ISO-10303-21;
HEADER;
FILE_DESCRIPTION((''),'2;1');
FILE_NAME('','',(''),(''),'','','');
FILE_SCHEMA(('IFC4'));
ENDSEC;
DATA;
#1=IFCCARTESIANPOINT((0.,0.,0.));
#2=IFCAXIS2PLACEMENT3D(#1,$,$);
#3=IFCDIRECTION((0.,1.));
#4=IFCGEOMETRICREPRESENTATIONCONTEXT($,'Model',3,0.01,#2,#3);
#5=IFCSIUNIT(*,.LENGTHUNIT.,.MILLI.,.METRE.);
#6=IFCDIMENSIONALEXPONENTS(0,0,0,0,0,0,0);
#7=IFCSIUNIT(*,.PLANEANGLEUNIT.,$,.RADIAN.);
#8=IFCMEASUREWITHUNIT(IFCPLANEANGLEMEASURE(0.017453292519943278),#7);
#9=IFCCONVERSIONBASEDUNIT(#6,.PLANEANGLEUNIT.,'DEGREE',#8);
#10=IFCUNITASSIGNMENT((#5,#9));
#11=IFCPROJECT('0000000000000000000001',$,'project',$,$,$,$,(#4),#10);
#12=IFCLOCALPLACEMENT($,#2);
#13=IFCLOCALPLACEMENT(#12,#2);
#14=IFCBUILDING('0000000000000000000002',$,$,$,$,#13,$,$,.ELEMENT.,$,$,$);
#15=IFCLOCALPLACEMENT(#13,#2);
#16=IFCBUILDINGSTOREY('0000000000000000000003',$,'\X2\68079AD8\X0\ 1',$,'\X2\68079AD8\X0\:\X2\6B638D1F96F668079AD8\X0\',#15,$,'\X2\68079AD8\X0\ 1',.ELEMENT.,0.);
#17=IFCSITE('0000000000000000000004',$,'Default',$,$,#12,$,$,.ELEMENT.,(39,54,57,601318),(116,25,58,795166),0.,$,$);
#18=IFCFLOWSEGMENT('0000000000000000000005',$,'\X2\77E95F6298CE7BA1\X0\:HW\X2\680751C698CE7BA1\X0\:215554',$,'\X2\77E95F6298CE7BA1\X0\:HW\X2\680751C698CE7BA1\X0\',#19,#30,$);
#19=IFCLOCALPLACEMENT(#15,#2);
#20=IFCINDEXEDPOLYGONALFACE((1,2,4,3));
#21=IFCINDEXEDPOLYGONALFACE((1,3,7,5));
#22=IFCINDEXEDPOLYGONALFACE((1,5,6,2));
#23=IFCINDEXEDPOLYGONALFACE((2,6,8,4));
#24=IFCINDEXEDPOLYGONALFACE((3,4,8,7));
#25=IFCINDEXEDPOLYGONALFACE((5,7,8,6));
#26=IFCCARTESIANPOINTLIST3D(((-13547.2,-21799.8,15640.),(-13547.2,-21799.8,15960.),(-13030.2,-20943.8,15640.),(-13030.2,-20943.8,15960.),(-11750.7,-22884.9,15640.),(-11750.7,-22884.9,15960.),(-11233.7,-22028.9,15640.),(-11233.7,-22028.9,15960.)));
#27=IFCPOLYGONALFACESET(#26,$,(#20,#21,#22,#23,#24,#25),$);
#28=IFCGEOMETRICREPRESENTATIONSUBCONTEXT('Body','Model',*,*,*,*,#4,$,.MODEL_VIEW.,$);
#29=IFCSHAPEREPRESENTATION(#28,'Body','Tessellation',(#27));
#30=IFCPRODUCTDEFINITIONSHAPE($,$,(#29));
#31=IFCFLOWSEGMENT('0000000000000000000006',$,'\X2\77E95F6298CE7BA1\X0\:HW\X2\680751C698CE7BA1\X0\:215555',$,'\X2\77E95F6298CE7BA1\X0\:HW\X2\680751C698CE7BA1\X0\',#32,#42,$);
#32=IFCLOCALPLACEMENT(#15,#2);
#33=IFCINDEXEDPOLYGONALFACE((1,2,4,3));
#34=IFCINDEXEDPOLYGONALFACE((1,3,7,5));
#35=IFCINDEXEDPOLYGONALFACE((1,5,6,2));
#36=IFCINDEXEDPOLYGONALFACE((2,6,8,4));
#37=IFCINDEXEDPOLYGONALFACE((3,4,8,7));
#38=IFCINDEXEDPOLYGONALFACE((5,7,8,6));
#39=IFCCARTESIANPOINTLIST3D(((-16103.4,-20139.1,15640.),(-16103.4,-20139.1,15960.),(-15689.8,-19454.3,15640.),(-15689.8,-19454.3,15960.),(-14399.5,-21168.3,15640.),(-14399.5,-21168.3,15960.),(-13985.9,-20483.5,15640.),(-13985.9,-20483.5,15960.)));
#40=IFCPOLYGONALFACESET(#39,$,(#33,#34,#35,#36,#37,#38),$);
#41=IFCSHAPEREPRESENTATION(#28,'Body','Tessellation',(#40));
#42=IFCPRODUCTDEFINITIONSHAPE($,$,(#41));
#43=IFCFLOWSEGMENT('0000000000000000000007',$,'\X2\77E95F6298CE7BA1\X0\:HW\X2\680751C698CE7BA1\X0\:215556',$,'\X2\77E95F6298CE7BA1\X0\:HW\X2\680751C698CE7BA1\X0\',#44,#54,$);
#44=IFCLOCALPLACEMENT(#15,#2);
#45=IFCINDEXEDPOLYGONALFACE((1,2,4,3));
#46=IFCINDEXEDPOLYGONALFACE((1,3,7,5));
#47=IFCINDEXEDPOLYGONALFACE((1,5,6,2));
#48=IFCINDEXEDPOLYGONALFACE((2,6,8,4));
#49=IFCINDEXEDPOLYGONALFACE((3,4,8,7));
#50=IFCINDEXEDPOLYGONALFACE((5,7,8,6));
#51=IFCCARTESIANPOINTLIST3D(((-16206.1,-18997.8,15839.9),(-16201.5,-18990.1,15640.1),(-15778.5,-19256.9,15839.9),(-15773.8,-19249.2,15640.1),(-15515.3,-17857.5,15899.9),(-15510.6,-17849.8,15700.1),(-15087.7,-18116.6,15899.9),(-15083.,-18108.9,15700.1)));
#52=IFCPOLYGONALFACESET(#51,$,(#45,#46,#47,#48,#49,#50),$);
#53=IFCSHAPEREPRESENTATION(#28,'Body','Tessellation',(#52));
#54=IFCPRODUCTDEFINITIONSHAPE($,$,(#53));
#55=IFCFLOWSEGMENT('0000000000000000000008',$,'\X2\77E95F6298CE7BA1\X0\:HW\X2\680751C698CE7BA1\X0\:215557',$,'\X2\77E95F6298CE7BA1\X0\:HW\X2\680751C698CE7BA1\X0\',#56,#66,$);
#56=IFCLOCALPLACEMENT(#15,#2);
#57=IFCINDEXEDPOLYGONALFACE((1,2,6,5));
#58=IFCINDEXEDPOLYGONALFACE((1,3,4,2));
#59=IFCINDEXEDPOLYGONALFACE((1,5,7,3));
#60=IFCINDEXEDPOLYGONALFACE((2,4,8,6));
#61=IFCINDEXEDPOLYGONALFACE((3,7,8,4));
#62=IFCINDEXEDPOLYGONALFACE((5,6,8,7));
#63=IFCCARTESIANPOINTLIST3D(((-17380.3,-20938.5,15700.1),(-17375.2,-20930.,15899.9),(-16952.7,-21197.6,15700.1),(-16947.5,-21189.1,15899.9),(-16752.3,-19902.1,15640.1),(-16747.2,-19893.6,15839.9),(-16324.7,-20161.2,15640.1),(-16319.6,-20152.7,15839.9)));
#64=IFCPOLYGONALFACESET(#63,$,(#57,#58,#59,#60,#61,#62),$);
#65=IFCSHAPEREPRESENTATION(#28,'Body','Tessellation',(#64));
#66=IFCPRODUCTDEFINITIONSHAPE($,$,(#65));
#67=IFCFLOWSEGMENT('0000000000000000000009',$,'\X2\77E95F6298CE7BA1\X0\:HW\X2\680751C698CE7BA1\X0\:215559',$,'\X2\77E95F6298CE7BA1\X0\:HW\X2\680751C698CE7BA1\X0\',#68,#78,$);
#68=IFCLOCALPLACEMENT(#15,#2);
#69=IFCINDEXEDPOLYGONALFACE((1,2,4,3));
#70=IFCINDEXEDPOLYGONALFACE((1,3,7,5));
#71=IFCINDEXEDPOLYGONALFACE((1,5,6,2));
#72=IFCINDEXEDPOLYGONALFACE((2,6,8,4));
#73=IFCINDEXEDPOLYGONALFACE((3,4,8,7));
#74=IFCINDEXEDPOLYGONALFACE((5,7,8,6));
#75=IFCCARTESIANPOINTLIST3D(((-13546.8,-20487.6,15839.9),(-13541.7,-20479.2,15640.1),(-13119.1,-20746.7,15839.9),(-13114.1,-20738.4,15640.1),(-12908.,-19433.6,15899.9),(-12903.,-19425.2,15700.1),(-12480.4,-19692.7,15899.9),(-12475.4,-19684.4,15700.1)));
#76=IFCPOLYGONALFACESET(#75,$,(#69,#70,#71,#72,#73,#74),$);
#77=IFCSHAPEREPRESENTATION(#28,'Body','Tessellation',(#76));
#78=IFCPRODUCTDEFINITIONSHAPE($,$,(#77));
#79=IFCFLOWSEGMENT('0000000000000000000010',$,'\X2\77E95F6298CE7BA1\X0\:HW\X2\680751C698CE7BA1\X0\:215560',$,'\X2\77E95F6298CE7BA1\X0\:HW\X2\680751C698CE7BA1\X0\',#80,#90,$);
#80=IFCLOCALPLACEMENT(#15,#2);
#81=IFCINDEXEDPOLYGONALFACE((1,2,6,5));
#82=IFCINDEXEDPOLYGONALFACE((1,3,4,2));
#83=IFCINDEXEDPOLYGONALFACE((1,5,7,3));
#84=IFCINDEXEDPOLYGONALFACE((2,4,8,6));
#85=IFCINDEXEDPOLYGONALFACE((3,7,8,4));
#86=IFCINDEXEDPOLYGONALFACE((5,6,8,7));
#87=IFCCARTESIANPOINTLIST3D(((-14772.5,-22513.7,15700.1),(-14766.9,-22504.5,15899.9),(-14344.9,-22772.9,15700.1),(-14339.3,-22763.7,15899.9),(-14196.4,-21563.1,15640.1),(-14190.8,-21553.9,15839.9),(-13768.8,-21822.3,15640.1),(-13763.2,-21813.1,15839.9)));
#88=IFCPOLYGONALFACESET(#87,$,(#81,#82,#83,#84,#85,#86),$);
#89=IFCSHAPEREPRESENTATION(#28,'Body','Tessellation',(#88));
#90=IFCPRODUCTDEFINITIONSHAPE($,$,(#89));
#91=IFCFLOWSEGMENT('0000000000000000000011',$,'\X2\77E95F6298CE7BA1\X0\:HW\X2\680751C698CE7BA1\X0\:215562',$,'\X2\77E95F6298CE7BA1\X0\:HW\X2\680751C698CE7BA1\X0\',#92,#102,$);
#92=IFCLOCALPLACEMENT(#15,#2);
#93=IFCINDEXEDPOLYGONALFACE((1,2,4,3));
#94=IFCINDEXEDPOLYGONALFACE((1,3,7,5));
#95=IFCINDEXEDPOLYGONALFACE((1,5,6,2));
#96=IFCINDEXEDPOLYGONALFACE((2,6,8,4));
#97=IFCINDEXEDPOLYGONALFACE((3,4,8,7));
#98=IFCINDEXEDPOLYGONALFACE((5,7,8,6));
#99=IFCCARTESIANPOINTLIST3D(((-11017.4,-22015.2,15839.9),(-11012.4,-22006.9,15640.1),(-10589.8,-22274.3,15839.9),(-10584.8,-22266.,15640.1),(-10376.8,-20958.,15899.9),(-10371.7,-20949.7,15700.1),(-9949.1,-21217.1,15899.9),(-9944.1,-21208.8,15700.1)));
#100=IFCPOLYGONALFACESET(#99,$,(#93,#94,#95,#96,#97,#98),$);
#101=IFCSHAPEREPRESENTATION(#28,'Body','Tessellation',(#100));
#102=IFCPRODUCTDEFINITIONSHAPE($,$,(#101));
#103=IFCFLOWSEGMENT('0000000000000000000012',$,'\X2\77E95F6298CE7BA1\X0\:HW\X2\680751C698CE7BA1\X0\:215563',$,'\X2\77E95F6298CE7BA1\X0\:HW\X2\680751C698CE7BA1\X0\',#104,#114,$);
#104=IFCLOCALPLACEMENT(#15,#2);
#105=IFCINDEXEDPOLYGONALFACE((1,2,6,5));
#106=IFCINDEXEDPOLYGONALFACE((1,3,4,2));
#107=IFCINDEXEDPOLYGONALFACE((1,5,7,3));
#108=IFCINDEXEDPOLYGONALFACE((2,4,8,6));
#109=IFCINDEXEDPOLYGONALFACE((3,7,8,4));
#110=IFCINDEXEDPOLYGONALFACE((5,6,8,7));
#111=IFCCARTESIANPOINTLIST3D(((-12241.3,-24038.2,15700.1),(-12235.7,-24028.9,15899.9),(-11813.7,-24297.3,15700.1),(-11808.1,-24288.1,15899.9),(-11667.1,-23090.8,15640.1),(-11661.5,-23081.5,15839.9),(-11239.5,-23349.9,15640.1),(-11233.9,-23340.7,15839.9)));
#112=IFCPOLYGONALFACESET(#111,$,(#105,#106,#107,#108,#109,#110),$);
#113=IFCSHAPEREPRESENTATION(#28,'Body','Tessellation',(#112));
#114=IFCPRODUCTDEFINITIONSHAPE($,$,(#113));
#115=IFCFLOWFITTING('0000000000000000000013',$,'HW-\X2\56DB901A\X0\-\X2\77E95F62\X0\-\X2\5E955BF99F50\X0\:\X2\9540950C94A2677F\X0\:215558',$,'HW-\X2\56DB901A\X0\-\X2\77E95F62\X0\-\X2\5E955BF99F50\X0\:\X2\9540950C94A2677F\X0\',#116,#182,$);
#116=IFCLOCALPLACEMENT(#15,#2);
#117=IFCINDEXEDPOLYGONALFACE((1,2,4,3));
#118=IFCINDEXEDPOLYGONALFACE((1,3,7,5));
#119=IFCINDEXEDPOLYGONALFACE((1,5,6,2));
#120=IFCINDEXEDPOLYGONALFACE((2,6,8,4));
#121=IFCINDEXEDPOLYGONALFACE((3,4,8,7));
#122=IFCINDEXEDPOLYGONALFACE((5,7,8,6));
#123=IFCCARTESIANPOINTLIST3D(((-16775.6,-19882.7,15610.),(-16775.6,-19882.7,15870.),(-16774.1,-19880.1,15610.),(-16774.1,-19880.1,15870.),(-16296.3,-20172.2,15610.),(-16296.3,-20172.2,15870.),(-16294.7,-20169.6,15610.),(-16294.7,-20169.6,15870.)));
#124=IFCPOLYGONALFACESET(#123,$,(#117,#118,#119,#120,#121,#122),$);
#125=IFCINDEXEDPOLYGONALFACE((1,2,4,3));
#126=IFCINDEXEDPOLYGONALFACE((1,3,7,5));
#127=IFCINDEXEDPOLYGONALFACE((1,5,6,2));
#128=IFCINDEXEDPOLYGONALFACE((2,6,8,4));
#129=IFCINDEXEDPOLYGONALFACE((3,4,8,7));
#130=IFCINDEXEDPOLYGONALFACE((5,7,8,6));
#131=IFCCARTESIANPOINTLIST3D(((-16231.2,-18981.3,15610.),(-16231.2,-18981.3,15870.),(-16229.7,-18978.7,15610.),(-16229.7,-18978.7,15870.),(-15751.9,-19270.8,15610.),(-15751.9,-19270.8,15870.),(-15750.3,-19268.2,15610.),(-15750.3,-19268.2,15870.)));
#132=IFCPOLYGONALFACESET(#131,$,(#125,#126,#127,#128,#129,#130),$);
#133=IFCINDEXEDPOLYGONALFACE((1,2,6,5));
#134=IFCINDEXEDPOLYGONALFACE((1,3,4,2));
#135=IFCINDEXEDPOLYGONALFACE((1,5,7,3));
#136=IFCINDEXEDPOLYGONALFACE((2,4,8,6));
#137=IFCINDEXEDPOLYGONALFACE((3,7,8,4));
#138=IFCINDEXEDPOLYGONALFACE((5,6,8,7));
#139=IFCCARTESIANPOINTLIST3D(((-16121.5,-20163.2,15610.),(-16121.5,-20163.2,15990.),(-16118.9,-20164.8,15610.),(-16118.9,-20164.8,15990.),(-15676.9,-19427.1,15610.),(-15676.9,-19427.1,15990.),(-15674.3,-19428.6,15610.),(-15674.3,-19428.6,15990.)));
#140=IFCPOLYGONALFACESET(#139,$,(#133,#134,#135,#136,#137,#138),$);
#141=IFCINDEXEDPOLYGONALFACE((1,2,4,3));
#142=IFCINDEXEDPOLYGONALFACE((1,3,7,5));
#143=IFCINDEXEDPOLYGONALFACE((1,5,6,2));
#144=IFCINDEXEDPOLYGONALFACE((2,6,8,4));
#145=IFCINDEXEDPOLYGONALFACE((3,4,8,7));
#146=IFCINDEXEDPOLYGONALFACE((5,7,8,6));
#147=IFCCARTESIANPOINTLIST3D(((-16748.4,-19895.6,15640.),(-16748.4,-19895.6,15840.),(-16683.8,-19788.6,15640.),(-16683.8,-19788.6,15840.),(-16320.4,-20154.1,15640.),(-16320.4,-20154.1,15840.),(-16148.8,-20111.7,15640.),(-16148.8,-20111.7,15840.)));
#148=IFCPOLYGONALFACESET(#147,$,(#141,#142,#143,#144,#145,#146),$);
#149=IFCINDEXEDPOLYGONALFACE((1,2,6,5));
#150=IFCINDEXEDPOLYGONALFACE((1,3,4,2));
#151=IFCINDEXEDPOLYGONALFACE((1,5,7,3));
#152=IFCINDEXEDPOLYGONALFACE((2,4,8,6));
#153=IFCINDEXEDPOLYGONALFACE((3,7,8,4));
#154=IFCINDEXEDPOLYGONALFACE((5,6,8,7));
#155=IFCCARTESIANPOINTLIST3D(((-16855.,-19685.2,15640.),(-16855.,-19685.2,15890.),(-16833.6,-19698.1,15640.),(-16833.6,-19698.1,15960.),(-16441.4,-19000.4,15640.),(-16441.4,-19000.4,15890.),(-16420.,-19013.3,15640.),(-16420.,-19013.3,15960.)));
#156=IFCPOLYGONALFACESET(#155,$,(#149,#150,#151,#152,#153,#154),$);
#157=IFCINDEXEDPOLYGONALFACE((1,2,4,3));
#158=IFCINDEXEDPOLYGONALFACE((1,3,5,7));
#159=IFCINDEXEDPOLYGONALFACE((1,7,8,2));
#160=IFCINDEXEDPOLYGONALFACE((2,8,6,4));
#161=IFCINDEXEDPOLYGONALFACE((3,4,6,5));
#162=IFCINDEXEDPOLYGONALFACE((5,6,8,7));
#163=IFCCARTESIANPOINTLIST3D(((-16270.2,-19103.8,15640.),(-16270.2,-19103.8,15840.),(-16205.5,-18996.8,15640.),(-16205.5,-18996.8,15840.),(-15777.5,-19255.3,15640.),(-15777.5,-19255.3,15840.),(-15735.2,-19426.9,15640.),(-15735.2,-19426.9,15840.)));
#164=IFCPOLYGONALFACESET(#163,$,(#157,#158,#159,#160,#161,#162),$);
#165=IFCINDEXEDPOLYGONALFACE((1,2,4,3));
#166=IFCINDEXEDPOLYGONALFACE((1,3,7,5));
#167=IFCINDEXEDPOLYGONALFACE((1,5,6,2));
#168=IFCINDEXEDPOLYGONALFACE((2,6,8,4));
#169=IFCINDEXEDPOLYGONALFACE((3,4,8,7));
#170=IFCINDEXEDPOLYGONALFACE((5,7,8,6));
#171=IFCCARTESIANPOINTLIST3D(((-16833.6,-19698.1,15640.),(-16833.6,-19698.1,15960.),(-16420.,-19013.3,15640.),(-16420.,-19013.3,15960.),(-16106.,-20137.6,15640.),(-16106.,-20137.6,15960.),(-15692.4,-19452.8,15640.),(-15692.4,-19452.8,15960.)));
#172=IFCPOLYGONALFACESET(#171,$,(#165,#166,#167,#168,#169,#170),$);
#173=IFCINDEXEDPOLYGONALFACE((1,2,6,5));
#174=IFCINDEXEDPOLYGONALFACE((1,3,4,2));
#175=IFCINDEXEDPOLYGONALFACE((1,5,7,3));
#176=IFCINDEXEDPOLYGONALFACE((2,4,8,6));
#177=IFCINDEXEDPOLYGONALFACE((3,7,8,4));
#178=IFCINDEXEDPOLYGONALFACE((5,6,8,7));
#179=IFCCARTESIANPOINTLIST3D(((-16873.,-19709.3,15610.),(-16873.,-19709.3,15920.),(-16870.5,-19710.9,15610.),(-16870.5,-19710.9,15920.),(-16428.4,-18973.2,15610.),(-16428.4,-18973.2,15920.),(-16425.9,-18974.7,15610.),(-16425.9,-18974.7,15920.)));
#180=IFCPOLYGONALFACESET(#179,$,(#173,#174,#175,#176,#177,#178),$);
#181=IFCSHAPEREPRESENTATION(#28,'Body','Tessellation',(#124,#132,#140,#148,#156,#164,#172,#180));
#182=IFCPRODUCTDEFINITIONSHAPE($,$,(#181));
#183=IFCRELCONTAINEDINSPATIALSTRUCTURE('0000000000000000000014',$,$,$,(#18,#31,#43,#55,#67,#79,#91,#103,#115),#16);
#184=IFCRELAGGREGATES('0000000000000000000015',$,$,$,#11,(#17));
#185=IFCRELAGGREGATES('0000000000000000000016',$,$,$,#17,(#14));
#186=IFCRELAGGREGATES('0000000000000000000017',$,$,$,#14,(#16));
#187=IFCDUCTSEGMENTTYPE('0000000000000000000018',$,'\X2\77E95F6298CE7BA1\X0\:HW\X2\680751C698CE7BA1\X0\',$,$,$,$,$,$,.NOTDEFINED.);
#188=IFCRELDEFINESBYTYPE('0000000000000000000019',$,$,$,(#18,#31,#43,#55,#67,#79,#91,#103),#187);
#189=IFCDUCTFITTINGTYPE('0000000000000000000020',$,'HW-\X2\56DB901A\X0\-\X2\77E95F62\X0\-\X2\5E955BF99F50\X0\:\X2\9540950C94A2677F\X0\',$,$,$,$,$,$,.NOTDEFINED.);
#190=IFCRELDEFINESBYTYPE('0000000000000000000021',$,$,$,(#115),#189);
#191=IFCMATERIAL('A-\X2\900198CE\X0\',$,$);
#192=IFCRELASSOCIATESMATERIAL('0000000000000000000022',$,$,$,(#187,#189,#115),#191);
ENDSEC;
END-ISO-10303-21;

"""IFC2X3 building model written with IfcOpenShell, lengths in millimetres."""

from ifc_helpers import new_model, entity, si_unit, converted_unit, direction, frame, frame_2d, origin, origin_2d_with_axis, place, context, subcontext, project, spatial, polyline, rectangle, outline, extrude, source, transform, mapped, material, type_object, type_shapes, element, save


model = new_model("IFC2X3")

# Units and contexts
model_context = context("Model", 3, precision=0.01, world=origin(), true_north=direction((0.0, 1.0)))
body_context = subcontext(model_context, "Body", "Model", "MODEL_VIEW")
ifc_project = project(units=[si_unit("LENGTHUNIT", "METRE", prefix="MILLI"), converted_unit("PLANEANGLEUNIT", "DEGREE", entity("IfcPlaneAngleMeasure", 0.017453292519943278), si_unit("PLANEANGLEUNIT", "RADIAN"), dimensions=[0, 0, 0, 0, 0, 0, 0])], contexts=[model_context])

# Site, building, storey
site_placement = place(None, origin())
site = spatial("IfcSite", under=ifc_project, at=site_placement, Name="Default", CompositionType="ELEMENT", RefLatitude=(39, 54, 57, 601318), RefLongitude=(116, 25, 58, 795166), RefElevation=0.0)
building_placement = place(site_placement, origin())
building = spatial("IfcBuilding", under=site, at=building_placement, CompositionType="ELEMENT")
storey_placement = place(building_placement, origin())
storey = spatial("IfcBuildingStorey", under=building, at=storey_placement, Name="标高 1", ObjectType="标高:正负零标高", LongName="标高 1", CompositionType="ELEMENT", Elevation=0.0)

# Flow segments
ifc_material = material(Name="A-送风")
duct_segment_type = type_object("IfcDuctSegmentType", Name="矩形风管:HW标准风管", PredefinedType="NOTDEFINED", material=ifc_material)
flow_segment_1_placement = place(storey_placement, origin())
element("IfcFlowSegment", 1, at=flow_segment_1_placement, inside=storey, type_object=duct_segment_type, Name="矩形风管:HW标准风管:215554", ObjectType="矩形风管:HW标准风管", context=body_context, shape_type="SweptSolid", body=[
    extrude(rectangle(XDim=2098.8, YDim=1000.0, at=frame_2d((0.0, 0.0), x_axis=(1.0, 0.0))), frame((-12390.5, -21914.4, 15640.0), z_axis=(0.0, 0.0, 1.0), x_axis=(-0.855986, 0.516998, 0.0)), (0.0, 0.0, 1.0), 320.0),
])
flow_segment_2_placement = place(storey_placement, origin())
element("IfcFlowSegment", 2, at=flow_segment_2_placement, inside=storey, type_object=duct_segment_type, Name="矩形风管:HW标准风管:215555", ObjectType="矩形风管:HW标准风管", context=body_context, shape_type="SweptSolid", body=[
    extrude(rectangle(XDim=1990.6, YDim=800.0, at=frame_2d((0.0, 0.0), x_axis=(1.0, 0.0))), frame((-15044.6, -20311.3, 15640.0), z_axis=(0.0, 0.0, 1.0), x_axis=(-0.855989, 0.516995, 0.0)), (0.0, 0.0, 1.0), 320.0),
])
flow_segment_3_placement = place(storey_placement, origin())
element("IfcFlowSegment", 3, at=flow_segment_3_placement, inside=storey, type_object=duct_segment_type, Name="矩形风管:HW标准风管:215556", ObjectType="矩形风管:HW标准风管", context=body_context, shape_type="SweptSolid", body=[
    extrude(rectangle(XDim=200.0, YDim=500.0, at=frame_2d((0.0, 0.0), x_axis=(1.0, 0.0))), frame((-15990.0, -19123.5, 15740.0), z_axis=(0.517651, 0.85441, 0.044959), x_axis=(-0.023296, -0.038452, 0.998989)), (0.0, 0.0, 1.0), 1334.6),
])
flow_segment_4_placement = place(storey_placement, origin())
element("IfcFlowSegment", 4, at=flow_segment_4_placement, inside=storey, type_object=duct_segment_type, Name="矩形风管:HW标准风管:215557", ObjectType="矩形风管:HW标准风管", context=body_context, shape_type="SweptSolid", body=[
    extrude(rectangle(XDim=200.0, YDim=500.0, at=frame_2d((0.0, 0.0), x_axis=(0.0, 1.0))), frame((-17163.9, -21063.8, 15800.0), z_axis=(0.517575, 0.854208, -0.049453), x_axis=(-0.855254, 0.518209, 0.0)), (0.0, 0.0, 1.0), 1213.3),
])
flow_segment_5_placement = place(storey_placement, origin())
element("IfcFlowSegment", 5, at=flow_segment_5_placement, inside=storey, type_object=duct_segment_type, Name="矩形风管:HW标准风管:215559", ObjectType="矩形风管:HW标准风管", context=body_context, shape_type="SweptSolid", body=[
    extrude(rectangle(XDim=200.0, YDim=500.0, at=frame_2d((0.0, 0.0), x_axis=(1.0, 0.0))), frame((-13330.4, -20613.0, 15740.0), z_axis=(0.517657, 0.854205, 0.048626), x_axis=(-0.025202, -0.041586, 0.998817)), (0.0, 0.0, 1.0), 1233.9),
])
flow_segment_6_placement = place(storey_placement, origin())
element("IfcFlowSegment", 6, at=flow_segment_6_placement, inside=storey, type_object=duct_segment_type, Name="矩形风管:HW标准风管:215560", ObjectType="矩形风管:HW标准风管", context=body_context, shape_type="SweptSolid", body=[
    extrude(rectangle(XDim=200.0, YDim=500.0, at=frame_2d((0.0, 0.0), x_axis=(0.0, 1.0))), frame((-14555.9, -22638.7, 15800.0), z_axis=(0.517563, 0.853946, -0.053899), x_axis=(-0.855189, 0.518316, 0.0)), (0.0, 0.0, 1.0), 1113.2),
])
flow_segment_7_placement = place(storey_placement, origin())
element("IfcFlowSegment", 7, at=flow_segment_7_placement, inside=storey, type_object=duct_segment_type, Name="矩形风管:HW标准风管:215562", ObjectType="矩形风管:HW标准风管", context=body_context, shape_type="SweptSolid", body=[
    extrude(rectangle(XDim=200.0, YDim=500.0, at=frame_2d((0.0, 0.0), x_axis=(1.0, 0.0))), frame((-10801.1, -22140.6, 15740.0), z_axis=(0.517659, 0.854212, 0.048478), x_axis=(-0.025125, -0.041459, 0.998824)), (0.0, 0.0, 1.0), 1237.7),
])
flow_segment_8_placement = place(storey_placement, origin())
element("IfcFlowSegment", 8, at=flow_segment_8_placement, inside=storey, type_object=duct_segment_type, Name="矩形风管:HW标准风管:215563", ObjectType="矩形风管:HW标准风管", context=body_context, shape_type="SweptSolid", body=[
    extrude(rectangle(XDim=200.0, YDim=500.0, at=frame_2d((0.0, 0.0), x_axis=(0.0, 1.0))), frame((-12024.7, -24163.1, 15800.0), z_axis=(0.51756, 0.853936, -0.054083), x_axis=(-0.855188, 0.518318, 0.0)), (0.0, 0.0, 1.0), 1109.4),
])

# Flow fitting
duct_fitting_type_1 = type_object("IfcDuctFittingType", Name="HW-四通-矩形-底对齐:镀锌钢板", PredefinedType="NOTDEFINED", material=ifc_material)
shared_shape_1 = source(origin(), body_context, "Body", "SweptSolid", [
    extrude(rectangle(XDim=560.0, YDim=3.0, at=origin_2d_with_axis()), frame((0.0, 526.5, -190.0), z_axis=(0.0, 0.0, 1.0), x_axis=(-1.0, 0.0, 0.0)), (0.0, 0.0, 1.0), 260.0),
    extrude(rectangle(XDim=560.0, YDim=3.0, at=frame_2d((0.0, 0.0), x_axis=(1.0, 0.0))), frame((0.0, -526.5, -190.0), z_axis=(0.0, 0.0, 1.0), x_axis=(-1.0, 0.0, 0.0)), (0.0, 0.0, 1.0), 260.0),
    extrude(rectangle(XDim=860.0, YDim=3.0, at=frame_2d((0.0, 0.0), x_axis=(1.0, 0.0))), frame((-426.5, 0.0, -190.0), z_axis=(0.0, 0.0, 1.0), x_axis=(0.0, 1.0, 0.0)), (0.0, 0.0, 1.0), 380.0),
    extrude(outline(polyline([(110.5, -198.9), (287.3, -198.9), (-154.7, 243.1), (-243.1, 154.7), (110.5, -198.9)])), frame((-31.2, 462.5, -160.0), z_axis=(0.0, 0.0, 1.0), x_axis=(-0.707107, -0.707107, 0.0)), (0.0, 0.0, 1.0), 200.0),
    extrude(outline(polyline([(-12.5, -142.5), (12.5, -142.5), (12.5, 177.5), (-12.5, 107.5), (-12.5, -142.5)])), frame((437.5, -400.0, -17.5), z_axis=(0.0, 1.0, 0.0), x_axis=(-1.0, 0.0, 0.0)), (0.0, 0.0, 1.0), 800.0),
    extrude(outline(polyline([(-62.5, -281.2), (62.5, -281.2), (62.5, 343.8), (-62.5, 218.7), (-62.5, -281.2)])), frame((-31.3, -462.5, -160.0), z_axis=(0.0, 0.0, 1.0), x_axis=(0.0, 1.0, 0.0)), (0.0, 0.0, 1.0), 200.0),
    extrude(rectangle(XDim=850.0, YDim=800.0, at=origin_2d_with_axis()), frame((0.0, 0.0, -160.0), z_axis=(0.0, 0.0, 1.0), x_axis=(-1.0, 0.0, 0.0)), (0.0, 0.0, 1.0), 320.0),
    extrude(rectangle(XDim=860.0, YDim=3.0, at=frame_2d((0.0, 0.0), x_axis=(1.0, 0.0))), frame((451.5, 0.0, -190.0), z_axis=(0.0, 0.0, 1.0), x_axis=(0.0, 1.0, 0.0)), (0.0, 0.0, 1.0), 310.0),
])
type_shapes(duct_fitting_type_1, [shared_shape_1])
flow_fitting_1_placement = place(storey_placement, frame((-16263.0, -19575.4, 15800.0), z_axis=(0.0, 0.0, 1.0), x_axis=(-0.855988, 0.516996, 0.0)))
element("IfcFlowFitting", 9, at=flow_fitting_1_placement, inside=storey, type_object=duct_fitting_type_1, material=ifc_material, Name="HW-四通-矩形-底对齐:镀锌钢板:215558", ObjectType="HW-四通-矩形-底对齐:镀锌钢板", context=body_context, shape_type="MappedRepresentation", body=[
    mapped(shared_shape_1, transform((0.0, 0.0, 0.0), scale=1.0)),
])

save(model, "model.ifc")
